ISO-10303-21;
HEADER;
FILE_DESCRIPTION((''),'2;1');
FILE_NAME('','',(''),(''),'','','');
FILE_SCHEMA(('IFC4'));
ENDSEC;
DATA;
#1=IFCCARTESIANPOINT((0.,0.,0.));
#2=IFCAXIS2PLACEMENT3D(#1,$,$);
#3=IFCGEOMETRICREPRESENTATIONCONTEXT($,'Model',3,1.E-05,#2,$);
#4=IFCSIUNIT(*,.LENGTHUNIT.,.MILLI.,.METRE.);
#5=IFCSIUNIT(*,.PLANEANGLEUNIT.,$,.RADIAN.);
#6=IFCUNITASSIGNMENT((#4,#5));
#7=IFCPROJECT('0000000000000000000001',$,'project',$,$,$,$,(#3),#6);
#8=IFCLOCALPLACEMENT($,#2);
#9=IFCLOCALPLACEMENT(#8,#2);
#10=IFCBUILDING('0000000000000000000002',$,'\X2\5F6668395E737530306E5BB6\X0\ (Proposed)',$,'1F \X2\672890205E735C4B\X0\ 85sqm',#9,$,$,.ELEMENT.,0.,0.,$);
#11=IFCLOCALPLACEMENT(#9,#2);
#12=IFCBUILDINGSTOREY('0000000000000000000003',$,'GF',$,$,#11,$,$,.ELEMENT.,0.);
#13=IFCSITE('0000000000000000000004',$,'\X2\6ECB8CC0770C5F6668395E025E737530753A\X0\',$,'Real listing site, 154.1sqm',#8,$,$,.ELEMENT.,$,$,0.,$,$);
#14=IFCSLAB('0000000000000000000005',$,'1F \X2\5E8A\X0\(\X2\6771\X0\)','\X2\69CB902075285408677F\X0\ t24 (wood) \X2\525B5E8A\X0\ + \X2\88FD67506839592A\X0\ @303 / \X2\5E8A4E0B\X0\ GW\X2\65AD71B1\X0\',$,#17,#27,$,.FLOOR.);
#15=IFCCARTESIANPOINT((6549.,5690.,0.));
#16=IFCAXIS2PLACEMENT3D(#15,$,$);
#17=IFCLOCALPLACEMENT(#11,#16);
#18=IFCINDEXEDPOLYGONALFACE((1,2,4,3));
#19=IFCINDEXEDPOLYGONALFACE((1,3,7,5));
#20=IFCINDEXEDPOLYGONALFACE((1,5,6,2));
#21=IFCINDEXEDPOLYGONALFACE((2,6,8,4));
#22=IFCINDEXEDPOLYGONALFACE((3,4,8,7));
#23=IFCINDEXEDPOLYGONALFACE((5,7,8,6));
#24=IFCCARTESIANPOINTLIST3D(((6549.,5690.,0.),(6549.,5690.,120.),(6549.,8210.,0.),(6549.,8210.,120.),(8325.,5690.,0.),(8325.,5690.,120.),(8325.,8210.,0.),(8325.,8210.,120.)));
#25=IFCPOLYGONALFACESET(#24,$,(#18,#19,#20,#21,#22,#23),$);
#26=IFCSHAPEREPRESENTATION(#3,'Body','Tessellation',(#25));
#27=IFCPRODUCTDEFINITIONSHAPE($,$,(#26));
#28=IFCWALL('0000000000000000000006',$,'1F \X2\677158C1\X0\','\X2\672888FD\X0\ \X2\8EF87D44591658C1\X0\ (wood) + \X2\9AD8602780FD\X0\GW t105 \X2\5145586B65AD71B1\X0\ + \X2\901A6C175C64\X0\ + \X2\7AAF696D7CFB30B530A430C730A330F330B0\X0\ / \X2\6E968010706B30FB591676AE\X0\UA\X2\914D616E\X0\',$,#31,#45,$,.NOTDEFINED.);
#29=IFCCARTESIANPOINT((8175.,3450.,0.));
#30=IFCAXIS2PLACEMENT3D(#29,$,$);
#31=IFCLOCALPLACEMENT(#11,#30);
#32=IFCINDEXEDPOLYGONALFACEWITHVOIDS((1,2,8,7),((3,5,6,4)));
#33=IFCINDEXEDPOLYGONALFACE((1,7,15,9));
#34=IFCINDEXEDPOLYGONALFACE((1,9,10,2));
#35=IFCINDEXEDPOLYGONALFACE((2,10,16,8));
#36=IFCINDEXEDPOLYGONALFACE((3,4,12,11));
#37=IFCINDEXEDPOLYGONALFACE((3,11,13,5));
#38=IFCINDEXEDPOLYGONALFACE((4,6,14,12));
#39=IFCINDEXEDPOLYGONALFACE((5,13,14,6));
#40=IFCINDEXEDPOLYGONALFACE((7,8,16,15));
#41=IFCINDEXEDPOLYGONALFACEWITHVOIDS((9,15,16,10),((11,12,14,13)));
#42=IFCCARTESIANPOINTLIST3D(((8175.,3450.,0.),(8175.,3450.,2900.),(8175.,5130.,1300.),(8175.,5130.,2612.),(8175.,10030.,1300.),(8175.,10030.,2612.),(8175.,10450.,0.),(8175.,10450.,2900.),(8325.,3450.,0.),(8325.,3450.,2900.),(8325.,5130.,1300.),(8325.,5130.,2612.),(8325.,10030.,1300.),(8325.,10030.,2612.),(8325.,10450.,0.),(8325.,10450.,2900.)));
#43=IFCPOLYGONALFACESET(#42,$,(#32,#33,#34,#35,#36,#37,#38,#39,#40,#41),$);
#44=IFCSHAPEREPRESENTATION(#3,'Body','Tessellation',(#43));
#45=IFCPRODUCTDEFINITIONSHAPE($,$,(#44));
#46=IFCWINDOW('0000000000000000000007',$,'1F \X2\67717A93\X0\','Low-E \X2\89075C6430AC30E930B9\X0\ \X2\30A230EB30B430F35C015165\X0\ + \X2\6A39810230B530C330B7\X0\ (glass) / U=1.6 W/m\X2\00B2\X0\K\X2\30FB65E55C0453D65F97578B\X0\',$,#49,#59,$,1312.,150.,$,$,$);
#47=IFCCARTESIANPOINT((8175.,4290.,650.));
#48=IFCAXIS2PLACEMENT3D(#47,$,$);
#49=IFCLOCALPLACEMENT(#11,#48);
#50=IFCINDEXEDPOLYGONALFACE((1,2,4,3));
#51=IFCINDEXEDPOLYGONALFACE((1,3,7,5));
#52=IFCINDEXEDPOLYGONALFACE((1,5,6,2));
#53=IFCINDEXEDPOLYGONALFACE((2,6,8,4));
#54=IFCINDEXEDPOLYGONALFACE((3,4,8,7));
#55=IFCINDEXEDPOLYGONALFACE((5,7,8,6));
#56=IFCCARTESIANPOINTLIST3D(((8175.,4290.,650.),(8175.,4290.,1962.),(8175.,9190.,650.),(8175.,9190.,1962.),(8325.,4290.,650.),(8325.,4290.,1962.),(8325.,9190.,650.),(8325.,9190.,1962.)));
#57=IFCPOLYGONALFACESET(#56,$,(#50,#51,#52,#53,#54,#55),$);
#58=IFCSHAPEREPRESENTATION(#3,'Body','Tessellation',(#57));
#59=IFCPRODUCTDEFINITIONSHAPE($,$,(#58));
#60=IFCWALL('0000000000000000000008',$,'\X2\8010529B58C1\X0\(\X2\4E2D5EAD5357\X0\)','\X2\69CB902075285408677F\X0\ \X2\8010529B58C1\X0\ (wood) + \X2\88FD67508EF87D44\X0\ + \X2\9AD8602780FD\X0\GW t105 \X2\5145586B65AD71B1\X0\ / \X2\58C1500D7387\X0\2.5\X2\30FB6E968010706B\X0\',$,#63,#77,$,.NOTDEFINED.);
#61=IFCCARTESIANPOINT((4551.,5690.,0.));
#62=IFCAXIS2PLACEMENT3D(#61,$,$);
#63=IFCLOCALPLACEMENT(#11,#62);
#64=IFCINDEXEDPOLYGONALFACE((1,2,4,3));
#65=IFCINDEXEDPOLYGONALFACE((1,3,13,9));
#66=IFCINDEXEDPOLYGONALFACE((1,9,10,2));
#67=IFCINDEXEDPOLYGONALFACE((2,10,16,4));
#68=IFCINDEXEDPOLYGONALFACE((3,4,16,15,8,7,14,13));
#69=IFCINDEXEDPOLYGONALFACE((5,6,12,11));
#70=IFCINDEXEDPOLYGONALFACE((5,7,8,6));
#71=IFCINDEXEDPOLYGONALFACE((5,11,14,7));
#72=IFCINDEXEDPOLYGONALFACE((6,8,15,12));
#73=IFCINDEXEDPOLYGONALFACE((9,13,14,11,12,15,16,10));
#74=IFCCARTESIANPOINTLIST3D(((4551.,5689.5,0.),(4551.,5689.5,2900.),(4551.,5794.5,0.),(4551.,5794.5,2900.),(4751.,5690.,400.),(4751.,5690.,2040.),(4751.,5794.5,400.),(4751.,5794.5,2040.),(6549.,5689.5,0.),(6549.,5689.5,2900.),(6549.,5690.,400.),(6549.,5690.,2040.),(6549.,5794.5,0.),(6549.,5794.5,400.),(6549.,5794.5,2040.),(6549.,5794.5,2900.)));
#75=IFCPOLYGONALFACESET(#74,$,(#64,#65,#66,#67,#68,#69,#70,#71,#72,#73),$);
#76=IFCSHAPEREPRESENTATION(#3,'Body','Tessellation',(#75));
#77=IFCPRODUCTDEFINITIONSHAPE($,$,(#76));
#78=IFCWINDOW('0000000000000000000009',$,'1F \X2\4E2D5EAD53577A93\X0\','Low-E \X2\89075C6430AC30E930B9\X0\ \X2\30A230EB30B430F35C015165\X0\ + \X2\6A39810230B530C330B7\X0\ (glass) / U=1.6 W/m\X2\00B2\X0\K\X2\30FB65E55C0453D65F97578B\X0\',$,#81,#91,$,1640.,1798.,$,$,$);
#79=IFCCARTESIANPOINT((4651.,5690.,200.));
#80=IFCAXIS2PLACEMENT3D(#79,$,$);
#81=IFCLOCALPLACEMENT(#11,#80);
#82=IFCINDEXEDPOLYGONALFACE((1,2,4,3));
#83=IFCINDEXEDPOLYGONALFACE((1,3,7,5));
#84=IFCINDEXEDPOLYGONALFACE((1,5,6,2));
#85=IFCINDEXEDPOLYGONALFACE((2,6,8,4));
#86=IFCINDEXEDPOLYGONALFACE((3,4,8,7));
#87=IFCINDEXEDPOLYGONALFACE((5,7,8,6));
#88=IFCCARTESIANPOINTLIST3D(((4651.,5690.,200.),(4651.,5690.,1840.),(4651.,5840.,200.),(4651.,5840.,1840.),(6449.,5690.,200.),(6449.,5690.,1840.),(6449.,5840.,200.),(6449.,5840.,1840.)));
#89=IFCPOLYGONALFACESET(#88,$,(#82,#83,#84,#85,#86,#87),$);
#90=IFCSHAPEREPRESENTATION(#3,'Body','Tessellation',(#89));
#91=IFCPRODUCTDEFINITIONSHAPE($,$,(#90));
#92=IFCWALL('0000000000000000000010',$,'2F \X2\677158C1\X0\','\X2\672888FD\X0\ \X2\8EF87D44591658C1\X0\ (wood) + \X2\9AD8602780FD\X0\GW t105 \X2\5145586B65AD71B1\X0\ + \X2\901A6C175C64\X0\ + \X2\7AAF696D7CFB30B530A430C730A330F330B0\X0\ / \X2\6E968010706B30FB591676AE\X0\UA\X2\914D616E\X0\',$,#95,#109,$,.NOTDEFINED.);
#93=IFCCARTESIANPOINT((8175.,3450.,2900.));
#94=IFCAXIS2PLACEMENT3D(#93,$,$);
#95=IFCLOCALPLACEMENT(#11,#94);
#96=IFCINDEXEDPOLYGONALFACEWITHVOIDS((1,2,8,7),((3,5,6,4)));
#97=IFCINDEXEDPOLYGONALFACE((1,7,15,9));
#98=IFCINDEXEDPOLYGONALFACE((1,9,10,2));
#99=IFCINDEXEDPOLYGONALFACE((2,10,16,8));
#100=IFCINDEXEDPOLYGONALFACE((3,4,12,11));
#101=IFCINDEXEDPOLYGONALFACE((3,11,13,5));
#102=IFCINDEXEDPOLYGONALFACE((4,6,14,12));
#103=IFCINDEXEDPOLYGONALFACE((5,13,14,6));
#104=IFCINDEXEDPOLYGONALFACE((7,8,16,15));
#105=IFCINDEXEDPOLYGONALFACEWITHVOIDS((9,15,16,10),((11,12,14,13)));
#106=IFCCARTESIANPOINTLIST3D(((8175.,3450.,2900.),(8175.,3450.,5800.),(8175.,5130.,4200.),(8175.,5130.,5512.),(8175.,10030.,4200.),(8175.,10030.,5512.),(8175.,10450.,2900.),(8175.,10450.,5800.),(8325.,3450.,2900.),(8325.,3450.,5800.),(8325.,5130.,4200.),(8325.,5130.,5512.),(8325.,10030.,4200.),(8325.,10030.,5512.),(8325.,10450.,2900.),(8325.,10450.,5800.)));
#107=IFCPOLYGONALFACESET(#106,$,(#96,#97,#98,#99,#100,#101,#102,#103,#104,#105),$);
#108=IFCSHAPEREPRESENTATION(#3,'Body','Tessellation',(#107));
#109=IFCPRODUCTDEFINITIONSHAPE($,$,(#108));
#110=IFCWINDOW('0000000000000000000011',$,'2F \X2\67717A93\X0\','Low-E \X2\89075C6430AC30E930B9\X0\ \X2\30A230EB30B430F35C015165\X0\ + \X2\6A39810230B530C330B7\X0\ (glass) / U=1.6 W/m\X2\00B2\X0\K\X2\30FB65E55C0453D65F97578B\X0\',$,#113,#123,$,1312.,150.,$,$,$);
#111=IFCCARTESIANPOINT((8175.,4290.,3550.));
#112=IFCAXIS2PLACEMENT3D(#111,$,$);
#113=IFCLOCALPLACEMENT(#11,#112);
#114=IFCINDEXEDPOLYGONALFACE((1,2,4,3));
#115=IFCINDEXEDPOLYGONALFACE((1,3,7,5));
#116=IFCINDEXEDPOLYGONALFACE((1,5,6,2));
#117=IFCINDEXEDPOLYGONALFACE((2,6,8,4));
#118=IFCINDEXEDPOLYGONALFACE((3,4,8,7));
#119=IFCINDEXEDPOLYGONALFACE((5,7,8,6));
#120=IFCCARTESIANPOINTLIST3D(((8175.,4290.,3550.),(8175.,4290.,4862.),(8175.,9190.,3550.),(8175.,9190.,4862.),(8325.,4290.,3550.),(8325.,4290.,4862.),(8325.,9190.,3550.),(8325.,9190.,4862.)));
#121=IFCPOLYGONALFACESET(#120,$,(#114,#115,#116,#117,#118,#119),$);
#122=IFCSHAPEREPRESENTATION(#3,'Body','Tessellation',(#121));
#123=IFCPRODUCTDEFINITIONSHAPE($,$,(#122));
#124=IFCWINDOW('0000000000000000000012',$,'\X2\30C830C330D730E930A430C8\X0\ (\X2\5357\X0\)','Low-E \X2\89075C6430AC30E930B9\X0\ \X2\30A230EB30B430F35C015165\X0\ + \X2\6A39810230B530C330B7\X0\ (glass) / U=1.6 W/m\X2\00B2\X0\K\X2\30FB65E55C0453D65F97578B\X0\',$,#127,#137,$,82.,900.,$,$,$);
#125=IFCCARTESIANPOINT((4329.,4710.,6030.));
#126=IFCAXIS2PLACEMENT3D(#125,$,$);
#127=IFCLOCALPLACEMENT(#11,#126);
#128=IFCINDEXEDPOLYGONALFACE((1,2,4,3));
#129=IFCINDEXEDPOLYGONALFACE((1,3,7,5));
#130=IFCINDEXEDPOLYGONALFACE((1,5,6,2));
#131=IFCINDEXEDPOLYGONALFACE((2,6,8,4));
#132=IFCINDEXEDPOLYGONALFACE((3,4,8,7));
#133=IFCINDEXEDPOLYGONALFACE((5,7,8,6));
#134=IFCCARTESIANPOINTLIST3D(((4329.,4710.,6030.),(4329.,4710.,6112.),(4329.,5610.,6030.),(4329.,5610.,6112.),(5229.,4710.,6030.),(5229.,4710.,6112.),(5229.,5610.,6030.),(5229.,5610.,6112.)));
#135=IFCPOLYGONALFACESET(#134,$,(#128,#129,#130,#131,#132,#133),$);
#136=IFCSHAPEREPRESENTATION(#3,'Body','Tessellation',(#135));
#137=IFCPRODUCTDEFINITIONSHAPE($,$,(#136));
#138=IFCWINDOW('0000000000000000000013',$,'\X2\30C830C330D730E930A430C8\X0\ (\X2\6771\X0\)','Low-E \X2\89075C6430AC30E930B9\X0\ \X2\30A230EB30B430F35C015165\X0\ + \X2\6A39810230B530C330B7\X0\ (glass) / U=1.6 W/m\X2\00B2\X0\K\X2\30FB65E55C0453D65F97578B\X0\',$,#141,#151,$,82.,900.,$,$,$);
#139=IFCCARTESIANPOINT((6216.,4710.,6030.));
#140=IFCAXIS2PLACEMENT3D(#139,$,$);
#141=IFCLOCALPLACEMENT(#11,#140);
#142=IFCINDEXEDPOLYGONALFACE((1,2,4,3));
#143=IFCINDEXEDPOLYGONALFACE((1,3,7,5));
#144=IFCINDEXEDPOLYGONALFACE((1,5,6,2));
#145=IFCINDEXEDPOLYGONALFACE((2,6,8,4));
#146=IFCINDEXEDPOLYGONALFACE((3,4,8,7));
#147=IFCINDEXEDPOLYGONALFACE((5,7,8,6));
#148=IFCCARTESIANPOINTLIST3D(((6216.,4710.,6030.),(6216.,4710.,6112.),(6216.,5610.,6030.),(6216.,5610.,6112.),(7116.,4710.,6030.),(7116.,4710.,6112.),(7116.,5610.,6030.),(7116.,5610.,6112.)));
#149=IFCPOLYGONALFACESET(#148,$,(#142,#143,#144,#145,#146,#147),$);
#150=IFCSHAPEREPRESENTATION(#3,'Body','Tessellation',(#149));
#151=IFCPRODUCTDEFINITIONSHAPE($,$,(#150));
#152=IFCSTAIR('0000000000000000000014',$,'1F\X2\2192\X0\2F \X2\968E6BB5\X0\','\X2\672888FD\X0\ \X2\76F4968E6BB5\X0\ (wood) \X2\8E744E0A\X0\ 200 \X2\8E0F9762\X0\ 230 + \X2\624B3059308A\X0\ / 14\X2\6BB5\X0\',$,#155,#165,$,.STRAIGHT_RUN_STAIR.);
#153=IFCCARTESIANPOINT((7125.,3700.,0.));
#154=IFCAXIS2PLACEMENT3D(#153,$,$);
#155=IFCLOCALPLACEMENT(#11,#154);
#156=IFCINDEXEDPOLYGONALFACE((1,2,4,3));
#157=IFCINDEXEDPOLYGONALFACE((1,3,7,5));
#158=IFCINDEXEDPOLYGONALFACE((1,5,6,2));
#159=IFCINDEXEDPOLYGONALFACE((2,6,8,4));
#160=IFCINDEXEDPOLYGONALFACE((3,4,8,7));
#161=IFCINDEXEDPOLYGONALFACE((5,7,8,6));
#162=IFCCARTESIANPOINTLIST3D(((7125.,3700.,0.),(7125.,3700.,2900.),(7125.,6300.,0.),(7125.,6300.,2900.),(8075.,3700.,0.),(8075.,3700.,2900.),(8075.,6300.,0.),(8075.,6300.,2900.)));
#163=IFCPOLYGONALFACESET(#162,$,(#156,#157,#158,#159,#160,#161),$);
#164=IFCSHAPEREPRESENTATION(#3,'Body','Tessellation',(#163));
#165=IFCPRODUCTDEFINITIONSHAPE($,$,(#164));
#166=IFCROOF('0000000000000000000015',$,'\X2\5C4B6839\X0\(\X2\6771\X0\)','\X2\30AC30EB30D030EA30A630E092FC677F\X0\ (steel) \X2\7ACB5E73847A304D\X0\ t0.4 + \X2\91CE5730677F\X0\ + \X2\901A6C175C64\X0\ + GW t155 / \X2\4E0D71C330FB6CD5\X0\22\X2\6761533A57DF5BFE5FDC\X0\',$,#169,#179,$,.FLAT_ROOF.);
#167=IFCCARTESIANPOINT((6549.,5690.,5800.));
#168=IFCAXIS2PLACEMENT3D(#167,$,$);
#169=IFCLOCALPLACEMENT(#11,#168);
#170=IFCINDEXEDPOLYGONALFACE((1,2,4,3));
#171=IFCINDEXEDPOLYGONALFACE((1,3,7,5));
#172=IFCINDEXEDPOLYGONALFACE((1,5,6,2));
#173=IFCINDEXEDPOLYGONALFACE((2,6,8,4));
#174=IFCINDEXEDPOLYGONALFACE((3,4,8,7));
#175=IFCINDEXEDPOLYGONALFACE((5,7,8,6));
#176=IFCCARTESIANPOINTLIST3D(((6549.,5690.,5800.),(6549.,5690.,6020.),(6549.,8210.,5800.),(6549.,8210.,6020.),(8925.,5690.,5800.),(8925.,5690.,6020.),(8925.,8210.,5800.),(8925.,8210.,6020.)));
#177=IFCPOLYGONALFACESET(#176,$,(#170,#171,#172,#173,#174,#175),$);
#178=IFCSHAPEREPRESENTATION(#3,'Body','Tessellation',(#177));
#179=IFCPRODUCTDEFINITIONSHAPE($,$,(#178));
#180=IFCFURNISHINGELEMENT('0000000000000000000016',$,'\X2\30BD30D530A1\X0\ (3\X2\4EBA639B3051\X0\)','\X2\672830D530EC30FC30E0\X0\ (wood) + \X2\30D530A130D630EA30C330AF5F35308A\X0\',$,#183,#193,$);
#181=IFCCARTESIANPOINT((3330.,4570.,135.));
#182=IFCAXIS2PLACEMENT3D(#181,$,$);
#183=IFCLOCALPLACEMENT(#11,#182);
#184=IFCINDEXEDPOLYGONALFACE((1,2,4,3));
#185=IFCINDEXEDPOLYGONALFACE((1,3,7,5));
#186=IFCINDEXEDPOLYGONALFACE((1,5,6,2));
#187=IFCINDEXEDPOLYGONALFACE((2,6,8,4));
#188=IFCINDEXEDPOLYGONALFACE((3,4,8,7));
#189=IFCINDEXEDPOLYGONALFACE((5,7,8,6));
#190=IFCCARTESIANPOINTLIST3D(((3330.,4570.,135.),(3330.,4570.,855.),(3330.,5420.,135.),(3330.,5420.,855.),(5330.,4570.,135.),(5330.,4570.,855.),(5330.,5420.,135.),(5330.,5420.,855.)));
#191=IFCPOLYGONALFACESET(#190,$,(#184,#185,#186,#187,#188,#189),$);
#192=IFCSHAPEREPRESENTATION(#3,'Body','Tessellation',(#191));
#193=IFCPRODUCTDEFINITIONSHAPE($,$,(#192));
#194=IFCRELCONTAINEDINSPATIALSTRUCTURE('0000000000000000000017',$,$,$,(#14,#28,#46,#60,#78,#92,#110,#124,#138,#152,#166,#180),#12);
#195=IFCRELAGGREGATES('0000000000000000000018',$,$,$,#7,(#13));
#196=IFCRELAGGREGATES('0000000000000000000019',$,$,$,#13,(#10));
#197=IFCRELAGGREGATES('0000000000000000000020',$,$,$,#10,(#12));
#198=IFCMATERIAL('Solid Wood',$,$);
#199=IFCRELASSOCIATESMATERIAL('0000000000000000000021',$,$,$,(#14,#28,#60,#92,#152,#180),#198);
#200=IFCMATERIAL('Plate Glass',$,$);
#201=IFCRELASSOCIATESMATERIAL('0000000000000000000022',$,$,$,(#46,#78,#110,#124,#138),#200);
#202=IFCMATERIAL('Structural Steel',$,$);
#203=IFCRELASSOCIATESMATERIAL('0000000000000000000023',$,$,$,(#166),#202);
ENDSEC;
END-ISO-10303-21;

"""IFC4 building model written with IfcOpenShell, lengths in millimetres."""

from ifc_helpers import new_model, si_unit, frame, frame_2d, origin, place, context, project, spatial, rectangle, extrude, material, element, fill, save


model = new_model("IFC4")

# Units and contexts
model_context = context("Model", 3, precision=1e-05, world=origin())
ifc_project = project(units=[si_unit("LENGTHUNIT", "METRE", prefix="MILLI"), si_unit("PLANEANGLEUNIT", "RADIAN")], contexts=[model_context])

# Site, building, storey
site_placement = place(None, origin())
site = spatial("IfcSite", under=ifc_project, at=site_placement, Name="滋賀県彦根市平田町", ObjectType="Real listing site, 154.1sqm", CompositionType="ELEMENT", RefElevation=0.0)
building_placement = place(site_placement, origin())
building = spatial("IfcBuilding", under=site, at=building_placement, Name="彦根平田の家 (Proposed)", ObjectType="1F 木造平屋 85sqm", CompositionType="ELEMENT", ElevationOfRefHeight=0.0, ElevationOfTerrain=0.0)
storey_placement = place(building_placement, origin())
storey = spatial("IfcBuildingStorey", under=building, at=storey_placement, Name="GF", CompositionType="ELEMENT", Elevation=0.0)

# Slab
ifc_material_1 = material(Name="Solid Wood")
slab_placement = place(storey_placement, frame((6549.0, 5690.0, 0.0)))
element("IfcSlab", 1, at=slab_placement, inside=storey, material=ifc_material_1, Name="1F 床(東)", Description="構造用合板 t24 (wood) 剛床 + 製材根太 @303 / 床下 GW断熱", PredefinedType="FLOOR", context=model_context, shape_type="SweptSolid", body=[
    extrude(rectangle(XDim=1776.0, YDim=2520.0, at=frame_2d((888.0, 1260.0))), frame((6549.0, 5690.0, 0.0)), (0.0, 0.0, 1.0), 120.0),
])

# Walls, openings, windows
wall_1_placement = place(storey_placement, frame((8175.0, 3450.0, 0.0)))
wall_1 = element("IfcWall", 2, at=wall_1_placement, inside=storey, material=ifc_material_1, Name="1F 東壁", Description="木製 軸組外壁 (wood) + 高性能GW t105 充填断熱 + 通気層 + 窯業系サイディング / 準耐火・外皮UA配慮", PredefinedType="NOTDEFINED", context=model_context, shape_type="SweptSolid", body=[
    extrude(rectangle(XDim=150.0, YDim=7000.0, at=frame_2d((75.0, 3500.0))), frame((8175.0, 3450.0, 0.0)), (0.0, 0.0, 1.0), 2900.0),
])
opening_1_placement = place(storey_placement, frame((8175.0, 4290.0, 650.0)))
opening_1 = element("IfcOpeningElement", 3, at=opening_1_placement, cuts=wall_1, PredefinedType="NOTDEFINED", context=model_context, shape_type="SweptSolid", body=[
    extrude(rectangle(XDim=150.0, YDim=4900.0, at=frame_2d((75.0, 2450.0))), frame((8175.0, 4290.0, 650.0)), (0.0, 0.0, 1.0), 1312.0),
])
ifc_material_2 = material(Name="Plate Glass")
window_1_placement = place(storey_placement, frame((8175.0, 4290.0, 650.0)))
window_1 = element("IfcWindow", 4, at=window_1_placement, inside=storey, material=ifc_material_2, Name="1F 東窓", Description="Low-E 複層ガラス アルゴン封入 + 樹脂サッシ (glass) / U=1.6 W/m²K・日射取得型", OverallHeight=1312.0, OverallWidth=150.0, context=model_context, shape_type="SweptSolid", body=[
    extrude(rectangle(XDim=150.0, YDim=4900.0, at=frame_2d((75.0, 2450.0))), frame((8175.0, 4290.0, 650.0)), (0.0, 0.0, 1.0), 1312.0),
])
fill(opening_1, window_1)
wall_2_placement = place(storey_placement, frame((4551.0, 5690.0, 0.0)))
wall_2 = element("IfcWall", 5, at=wall_2_placement, inside=storey, material=ifc_material_1, Name="耐力壁(中庭南)", Description="構造用合板 耐力壁 (wood) + 製材軸組 + 高性能GW t105 充填断熱 / 壁倍率2.5・準耐火", PredefinedType="NOTDEFINED", context=model_context, shape_type="SweptSolid", body=[
    extrude(rectangle(XDim=1998.0, YDim=105.0, at=frame_2d((999.0, 52.0))), frame((4551.0, 5690.0, 0.0)), (0.0, 0.0, 1.0), 2900.0),
])
opening_2_placement = place(storey_placement, frame((4651.0, 5690.0, 200.0)))
opening_2 = element("IfcOpeningElement", 6, at=opening_2_placement, cuts=wall_2, PredefinedType="NOTDEFINED", context=model_context, shape_type="SweptSolid", body=[
    extrude(rectangle(XDim=1798.0, YDim=150.0, at=frame_2d((899.0, 75.0))), frame((4651.0, 5690.0, 200.0)), (0.0, 0.0, 1.0), 1640.0),
])
window_2_placement = place(storey_placement, frame((4651.0, 5690.0, 200.0)))
window_2 = element("IfcWindow", 7, at=window_2_placement, inside=storey, material=ifc_material_2, Name="1F 中庭南窓", Description="Low-E 複層ガラス アルゴン封入 + 樹脂サッシ (glass) / U=1.6 W/m²K・日射取得型", OverallHeight=1640.0, OverallWidth=1798.0, context=model_context, shape_type="SweptSolid", body=[
    extrude(rectangle(XDim=1798.0, YDim=150.0, at=frame_2d((899.0, 75.0))), frame((4651.0, 5690.0, 200.0)), (0.0, 0.0, 1.0), 1640.0),
])
fill(opening_2, window_2)

# Wall, opening, window
wall_3_placement = place(storey_placement, frame((8175.0, 3450.0, 2900.0)))
wall_3 = element("IfcWall", 8, at=wall_3_placement, inside=storey, material=ifc_material_1, Name="2F 東壁", Description="木製 軸組外壁 (wood) + 高性能GW t105 充填断熱 + 通気層 + 窯業系サイディング / 準耐火・外皮UA配慮", PredefinedType="NOTDEFINED", context=model_context, shape_type="SweptSolid", body=[
    extrude(rectangle(XDim=150.0, YDim=7000.0, at=frame_2d((75.0, 3500.0))), frame((8175.0, 3450.0, 2900.0)), (0.0, 0.0, 1.0), 2900.0),
])
opening_3_placement = place(storey_placement, frame((8175.0, 4290.0, 3550.0)))
opening_3 = element("IfcOpeningElement", 9, at=opening_3_placement, cuts=wall_3, PredefinedType="NOTDEFINED", context=model_context, shape_type="SweptSolid", body=[
    extrude(rectangle(XDim=150.0, YDim=4900.0, at=frame_2d((75.0, 2450.0))), frame((8175.0, 4290.0, 3550.0)), (0.0, 0.0, 1.0), 1312.0),
])
window_3_placement = place(storey_placement, frame((8175.0, 4290.0, 3550.0)))
window_3 = element("IfcWindow", 10, at=window_3_placement, inside=storey, material=ifc_material_2, Name="2F 東窓", Description="Low-E 複層ガラス アルゴン封入 + 樹脂サッシ (glass) / U=1.6 W/m²K・日射取得型", OverallHeight=1312.0, OverallWidth=150.0, context=model_context, shape_type="SweptSolid", body=[
    extrude(rectangle(XDim=150.0, YDim=4900.0, at=frame_2d((75.0, 2450.0))), frame((8175.0, 4290.0, 3550.0)), (0.0, 0.0, 1.0), 1312.0),
])
fill(opening_3, window_3)

# Windows
window_4_placement = place(storey_placement, frame((4329.0, 4710.0, 6030.0)))
element("IfcWindow", 11, at=window_4_placement, inside=storey, material=ifc_material_2, Name="トップライト (南)", Description="Low-E 複層ガラス アルゴン封入 + 樹脂サッシ (glass) / U=1.6 W/m²K・日射取得型", OverallHeight=82.0, OverallWidth=900.0, context=model_context, shape_type="SweptSolid", body=[
    extrude(rectangle(XDim=900.0, YDim=900.0, at=frame_2d((450.0, 450.0))), frame((4329.0, 4710.0, 6030.0)), (0.0, 0.0, 1.0), 82.0),
])
window_5_placement = place(storey_placement, frame((6216.0, 4710.0, 6030.0)))
element("IfcWindow", 12, at=window_5_placement, inside=storey, material=ifc_material_2, Name="トップライト (東)", Description="Low-E 複層ガラス アルゴン封入 + 樹脂サッシ (glass) / U=1.6 W/m²K・日射取得型", OverallHeight=82.0, OverallWidth=900.0, context=model_context, shape_type="SweptSolid", body=[
    extrude(rectangle(XDim=900.0, YDim=900.0, at=frame_2d((450.0, 450.0))), frame((6216.0, 4710.0, 6030.0)), (0.0, 0.0, 1.0), 82.0),
])

# Stair
stair_placement = place(storey_placement, frame((7125.0, 3700.0, 0.0)))
element("IfcStair", 13, at=stair_placement, inside=storey, material=ifc_material_1, Name="1F→2F 階段", Description="木製 直階段 (wood) 蹴上 200 踏面 230 + 手すり / 14段", PredefinedType="STRAIGHT_RUN_STAIR", context=model_context, shape_type="SweptSolid", body=[
    extrude(rectangle(XDim=950.0, YDim=2600.0, at=frame_2d((475.0, 1300.0))), frame((7125.0, 3700.0, 0.0)), (0.0, 0.0, 1.0), 2900.0),
])

# Roof
ifc_material_3 = material(Name="Structural Steel")
roof_placement = place(storey_placement, frame((6549.0, 5690.0, 5800.0)))
element("IfcRoof", 14, at=roof_placement, inside=storey, material=ifc_material_3, Name="屋根(東)", Description="ガルバリウム鋼板 (steel) 立平葺き t0.4 + 野地板 + 通気層 + GW t155 / 不燃・法22条区域対応", PredefinedType="FLAT_ROOF", context=model_context, shape_type="SweptSolid", body=[
    extrude(rectangle(XDim=2376.0, YDim=2520.0, at=frame_2d((1188.0, 1260.0))), frame((6549.0, 5690.0, 5800.0)), (0.0, 0.0, 1.0), 220.0),
])

# Furnishing element
furnishing_1_placement = place(storey_placement, frame((3330.0, 4570.0, 135.0)))
element("IfcFurnishingElement", 15, at=furnishing_1_placement, inside=storey, material=ifc_material_1, Name="ソファ (3人掛け)", Description="木フレーム (wood) + ファブリック張り", context=model_context, shape_type="SweptSolid", body=[
    extrude(rectangle(XDim=2000.0, YDim=850.0, at=frame_2d((1000.0, 425.0))), frame((3330.0, 4570.0, 135.0)), (0.0, 0.0, 1.0), 720.0),
])

save(model, "model.ifc")
